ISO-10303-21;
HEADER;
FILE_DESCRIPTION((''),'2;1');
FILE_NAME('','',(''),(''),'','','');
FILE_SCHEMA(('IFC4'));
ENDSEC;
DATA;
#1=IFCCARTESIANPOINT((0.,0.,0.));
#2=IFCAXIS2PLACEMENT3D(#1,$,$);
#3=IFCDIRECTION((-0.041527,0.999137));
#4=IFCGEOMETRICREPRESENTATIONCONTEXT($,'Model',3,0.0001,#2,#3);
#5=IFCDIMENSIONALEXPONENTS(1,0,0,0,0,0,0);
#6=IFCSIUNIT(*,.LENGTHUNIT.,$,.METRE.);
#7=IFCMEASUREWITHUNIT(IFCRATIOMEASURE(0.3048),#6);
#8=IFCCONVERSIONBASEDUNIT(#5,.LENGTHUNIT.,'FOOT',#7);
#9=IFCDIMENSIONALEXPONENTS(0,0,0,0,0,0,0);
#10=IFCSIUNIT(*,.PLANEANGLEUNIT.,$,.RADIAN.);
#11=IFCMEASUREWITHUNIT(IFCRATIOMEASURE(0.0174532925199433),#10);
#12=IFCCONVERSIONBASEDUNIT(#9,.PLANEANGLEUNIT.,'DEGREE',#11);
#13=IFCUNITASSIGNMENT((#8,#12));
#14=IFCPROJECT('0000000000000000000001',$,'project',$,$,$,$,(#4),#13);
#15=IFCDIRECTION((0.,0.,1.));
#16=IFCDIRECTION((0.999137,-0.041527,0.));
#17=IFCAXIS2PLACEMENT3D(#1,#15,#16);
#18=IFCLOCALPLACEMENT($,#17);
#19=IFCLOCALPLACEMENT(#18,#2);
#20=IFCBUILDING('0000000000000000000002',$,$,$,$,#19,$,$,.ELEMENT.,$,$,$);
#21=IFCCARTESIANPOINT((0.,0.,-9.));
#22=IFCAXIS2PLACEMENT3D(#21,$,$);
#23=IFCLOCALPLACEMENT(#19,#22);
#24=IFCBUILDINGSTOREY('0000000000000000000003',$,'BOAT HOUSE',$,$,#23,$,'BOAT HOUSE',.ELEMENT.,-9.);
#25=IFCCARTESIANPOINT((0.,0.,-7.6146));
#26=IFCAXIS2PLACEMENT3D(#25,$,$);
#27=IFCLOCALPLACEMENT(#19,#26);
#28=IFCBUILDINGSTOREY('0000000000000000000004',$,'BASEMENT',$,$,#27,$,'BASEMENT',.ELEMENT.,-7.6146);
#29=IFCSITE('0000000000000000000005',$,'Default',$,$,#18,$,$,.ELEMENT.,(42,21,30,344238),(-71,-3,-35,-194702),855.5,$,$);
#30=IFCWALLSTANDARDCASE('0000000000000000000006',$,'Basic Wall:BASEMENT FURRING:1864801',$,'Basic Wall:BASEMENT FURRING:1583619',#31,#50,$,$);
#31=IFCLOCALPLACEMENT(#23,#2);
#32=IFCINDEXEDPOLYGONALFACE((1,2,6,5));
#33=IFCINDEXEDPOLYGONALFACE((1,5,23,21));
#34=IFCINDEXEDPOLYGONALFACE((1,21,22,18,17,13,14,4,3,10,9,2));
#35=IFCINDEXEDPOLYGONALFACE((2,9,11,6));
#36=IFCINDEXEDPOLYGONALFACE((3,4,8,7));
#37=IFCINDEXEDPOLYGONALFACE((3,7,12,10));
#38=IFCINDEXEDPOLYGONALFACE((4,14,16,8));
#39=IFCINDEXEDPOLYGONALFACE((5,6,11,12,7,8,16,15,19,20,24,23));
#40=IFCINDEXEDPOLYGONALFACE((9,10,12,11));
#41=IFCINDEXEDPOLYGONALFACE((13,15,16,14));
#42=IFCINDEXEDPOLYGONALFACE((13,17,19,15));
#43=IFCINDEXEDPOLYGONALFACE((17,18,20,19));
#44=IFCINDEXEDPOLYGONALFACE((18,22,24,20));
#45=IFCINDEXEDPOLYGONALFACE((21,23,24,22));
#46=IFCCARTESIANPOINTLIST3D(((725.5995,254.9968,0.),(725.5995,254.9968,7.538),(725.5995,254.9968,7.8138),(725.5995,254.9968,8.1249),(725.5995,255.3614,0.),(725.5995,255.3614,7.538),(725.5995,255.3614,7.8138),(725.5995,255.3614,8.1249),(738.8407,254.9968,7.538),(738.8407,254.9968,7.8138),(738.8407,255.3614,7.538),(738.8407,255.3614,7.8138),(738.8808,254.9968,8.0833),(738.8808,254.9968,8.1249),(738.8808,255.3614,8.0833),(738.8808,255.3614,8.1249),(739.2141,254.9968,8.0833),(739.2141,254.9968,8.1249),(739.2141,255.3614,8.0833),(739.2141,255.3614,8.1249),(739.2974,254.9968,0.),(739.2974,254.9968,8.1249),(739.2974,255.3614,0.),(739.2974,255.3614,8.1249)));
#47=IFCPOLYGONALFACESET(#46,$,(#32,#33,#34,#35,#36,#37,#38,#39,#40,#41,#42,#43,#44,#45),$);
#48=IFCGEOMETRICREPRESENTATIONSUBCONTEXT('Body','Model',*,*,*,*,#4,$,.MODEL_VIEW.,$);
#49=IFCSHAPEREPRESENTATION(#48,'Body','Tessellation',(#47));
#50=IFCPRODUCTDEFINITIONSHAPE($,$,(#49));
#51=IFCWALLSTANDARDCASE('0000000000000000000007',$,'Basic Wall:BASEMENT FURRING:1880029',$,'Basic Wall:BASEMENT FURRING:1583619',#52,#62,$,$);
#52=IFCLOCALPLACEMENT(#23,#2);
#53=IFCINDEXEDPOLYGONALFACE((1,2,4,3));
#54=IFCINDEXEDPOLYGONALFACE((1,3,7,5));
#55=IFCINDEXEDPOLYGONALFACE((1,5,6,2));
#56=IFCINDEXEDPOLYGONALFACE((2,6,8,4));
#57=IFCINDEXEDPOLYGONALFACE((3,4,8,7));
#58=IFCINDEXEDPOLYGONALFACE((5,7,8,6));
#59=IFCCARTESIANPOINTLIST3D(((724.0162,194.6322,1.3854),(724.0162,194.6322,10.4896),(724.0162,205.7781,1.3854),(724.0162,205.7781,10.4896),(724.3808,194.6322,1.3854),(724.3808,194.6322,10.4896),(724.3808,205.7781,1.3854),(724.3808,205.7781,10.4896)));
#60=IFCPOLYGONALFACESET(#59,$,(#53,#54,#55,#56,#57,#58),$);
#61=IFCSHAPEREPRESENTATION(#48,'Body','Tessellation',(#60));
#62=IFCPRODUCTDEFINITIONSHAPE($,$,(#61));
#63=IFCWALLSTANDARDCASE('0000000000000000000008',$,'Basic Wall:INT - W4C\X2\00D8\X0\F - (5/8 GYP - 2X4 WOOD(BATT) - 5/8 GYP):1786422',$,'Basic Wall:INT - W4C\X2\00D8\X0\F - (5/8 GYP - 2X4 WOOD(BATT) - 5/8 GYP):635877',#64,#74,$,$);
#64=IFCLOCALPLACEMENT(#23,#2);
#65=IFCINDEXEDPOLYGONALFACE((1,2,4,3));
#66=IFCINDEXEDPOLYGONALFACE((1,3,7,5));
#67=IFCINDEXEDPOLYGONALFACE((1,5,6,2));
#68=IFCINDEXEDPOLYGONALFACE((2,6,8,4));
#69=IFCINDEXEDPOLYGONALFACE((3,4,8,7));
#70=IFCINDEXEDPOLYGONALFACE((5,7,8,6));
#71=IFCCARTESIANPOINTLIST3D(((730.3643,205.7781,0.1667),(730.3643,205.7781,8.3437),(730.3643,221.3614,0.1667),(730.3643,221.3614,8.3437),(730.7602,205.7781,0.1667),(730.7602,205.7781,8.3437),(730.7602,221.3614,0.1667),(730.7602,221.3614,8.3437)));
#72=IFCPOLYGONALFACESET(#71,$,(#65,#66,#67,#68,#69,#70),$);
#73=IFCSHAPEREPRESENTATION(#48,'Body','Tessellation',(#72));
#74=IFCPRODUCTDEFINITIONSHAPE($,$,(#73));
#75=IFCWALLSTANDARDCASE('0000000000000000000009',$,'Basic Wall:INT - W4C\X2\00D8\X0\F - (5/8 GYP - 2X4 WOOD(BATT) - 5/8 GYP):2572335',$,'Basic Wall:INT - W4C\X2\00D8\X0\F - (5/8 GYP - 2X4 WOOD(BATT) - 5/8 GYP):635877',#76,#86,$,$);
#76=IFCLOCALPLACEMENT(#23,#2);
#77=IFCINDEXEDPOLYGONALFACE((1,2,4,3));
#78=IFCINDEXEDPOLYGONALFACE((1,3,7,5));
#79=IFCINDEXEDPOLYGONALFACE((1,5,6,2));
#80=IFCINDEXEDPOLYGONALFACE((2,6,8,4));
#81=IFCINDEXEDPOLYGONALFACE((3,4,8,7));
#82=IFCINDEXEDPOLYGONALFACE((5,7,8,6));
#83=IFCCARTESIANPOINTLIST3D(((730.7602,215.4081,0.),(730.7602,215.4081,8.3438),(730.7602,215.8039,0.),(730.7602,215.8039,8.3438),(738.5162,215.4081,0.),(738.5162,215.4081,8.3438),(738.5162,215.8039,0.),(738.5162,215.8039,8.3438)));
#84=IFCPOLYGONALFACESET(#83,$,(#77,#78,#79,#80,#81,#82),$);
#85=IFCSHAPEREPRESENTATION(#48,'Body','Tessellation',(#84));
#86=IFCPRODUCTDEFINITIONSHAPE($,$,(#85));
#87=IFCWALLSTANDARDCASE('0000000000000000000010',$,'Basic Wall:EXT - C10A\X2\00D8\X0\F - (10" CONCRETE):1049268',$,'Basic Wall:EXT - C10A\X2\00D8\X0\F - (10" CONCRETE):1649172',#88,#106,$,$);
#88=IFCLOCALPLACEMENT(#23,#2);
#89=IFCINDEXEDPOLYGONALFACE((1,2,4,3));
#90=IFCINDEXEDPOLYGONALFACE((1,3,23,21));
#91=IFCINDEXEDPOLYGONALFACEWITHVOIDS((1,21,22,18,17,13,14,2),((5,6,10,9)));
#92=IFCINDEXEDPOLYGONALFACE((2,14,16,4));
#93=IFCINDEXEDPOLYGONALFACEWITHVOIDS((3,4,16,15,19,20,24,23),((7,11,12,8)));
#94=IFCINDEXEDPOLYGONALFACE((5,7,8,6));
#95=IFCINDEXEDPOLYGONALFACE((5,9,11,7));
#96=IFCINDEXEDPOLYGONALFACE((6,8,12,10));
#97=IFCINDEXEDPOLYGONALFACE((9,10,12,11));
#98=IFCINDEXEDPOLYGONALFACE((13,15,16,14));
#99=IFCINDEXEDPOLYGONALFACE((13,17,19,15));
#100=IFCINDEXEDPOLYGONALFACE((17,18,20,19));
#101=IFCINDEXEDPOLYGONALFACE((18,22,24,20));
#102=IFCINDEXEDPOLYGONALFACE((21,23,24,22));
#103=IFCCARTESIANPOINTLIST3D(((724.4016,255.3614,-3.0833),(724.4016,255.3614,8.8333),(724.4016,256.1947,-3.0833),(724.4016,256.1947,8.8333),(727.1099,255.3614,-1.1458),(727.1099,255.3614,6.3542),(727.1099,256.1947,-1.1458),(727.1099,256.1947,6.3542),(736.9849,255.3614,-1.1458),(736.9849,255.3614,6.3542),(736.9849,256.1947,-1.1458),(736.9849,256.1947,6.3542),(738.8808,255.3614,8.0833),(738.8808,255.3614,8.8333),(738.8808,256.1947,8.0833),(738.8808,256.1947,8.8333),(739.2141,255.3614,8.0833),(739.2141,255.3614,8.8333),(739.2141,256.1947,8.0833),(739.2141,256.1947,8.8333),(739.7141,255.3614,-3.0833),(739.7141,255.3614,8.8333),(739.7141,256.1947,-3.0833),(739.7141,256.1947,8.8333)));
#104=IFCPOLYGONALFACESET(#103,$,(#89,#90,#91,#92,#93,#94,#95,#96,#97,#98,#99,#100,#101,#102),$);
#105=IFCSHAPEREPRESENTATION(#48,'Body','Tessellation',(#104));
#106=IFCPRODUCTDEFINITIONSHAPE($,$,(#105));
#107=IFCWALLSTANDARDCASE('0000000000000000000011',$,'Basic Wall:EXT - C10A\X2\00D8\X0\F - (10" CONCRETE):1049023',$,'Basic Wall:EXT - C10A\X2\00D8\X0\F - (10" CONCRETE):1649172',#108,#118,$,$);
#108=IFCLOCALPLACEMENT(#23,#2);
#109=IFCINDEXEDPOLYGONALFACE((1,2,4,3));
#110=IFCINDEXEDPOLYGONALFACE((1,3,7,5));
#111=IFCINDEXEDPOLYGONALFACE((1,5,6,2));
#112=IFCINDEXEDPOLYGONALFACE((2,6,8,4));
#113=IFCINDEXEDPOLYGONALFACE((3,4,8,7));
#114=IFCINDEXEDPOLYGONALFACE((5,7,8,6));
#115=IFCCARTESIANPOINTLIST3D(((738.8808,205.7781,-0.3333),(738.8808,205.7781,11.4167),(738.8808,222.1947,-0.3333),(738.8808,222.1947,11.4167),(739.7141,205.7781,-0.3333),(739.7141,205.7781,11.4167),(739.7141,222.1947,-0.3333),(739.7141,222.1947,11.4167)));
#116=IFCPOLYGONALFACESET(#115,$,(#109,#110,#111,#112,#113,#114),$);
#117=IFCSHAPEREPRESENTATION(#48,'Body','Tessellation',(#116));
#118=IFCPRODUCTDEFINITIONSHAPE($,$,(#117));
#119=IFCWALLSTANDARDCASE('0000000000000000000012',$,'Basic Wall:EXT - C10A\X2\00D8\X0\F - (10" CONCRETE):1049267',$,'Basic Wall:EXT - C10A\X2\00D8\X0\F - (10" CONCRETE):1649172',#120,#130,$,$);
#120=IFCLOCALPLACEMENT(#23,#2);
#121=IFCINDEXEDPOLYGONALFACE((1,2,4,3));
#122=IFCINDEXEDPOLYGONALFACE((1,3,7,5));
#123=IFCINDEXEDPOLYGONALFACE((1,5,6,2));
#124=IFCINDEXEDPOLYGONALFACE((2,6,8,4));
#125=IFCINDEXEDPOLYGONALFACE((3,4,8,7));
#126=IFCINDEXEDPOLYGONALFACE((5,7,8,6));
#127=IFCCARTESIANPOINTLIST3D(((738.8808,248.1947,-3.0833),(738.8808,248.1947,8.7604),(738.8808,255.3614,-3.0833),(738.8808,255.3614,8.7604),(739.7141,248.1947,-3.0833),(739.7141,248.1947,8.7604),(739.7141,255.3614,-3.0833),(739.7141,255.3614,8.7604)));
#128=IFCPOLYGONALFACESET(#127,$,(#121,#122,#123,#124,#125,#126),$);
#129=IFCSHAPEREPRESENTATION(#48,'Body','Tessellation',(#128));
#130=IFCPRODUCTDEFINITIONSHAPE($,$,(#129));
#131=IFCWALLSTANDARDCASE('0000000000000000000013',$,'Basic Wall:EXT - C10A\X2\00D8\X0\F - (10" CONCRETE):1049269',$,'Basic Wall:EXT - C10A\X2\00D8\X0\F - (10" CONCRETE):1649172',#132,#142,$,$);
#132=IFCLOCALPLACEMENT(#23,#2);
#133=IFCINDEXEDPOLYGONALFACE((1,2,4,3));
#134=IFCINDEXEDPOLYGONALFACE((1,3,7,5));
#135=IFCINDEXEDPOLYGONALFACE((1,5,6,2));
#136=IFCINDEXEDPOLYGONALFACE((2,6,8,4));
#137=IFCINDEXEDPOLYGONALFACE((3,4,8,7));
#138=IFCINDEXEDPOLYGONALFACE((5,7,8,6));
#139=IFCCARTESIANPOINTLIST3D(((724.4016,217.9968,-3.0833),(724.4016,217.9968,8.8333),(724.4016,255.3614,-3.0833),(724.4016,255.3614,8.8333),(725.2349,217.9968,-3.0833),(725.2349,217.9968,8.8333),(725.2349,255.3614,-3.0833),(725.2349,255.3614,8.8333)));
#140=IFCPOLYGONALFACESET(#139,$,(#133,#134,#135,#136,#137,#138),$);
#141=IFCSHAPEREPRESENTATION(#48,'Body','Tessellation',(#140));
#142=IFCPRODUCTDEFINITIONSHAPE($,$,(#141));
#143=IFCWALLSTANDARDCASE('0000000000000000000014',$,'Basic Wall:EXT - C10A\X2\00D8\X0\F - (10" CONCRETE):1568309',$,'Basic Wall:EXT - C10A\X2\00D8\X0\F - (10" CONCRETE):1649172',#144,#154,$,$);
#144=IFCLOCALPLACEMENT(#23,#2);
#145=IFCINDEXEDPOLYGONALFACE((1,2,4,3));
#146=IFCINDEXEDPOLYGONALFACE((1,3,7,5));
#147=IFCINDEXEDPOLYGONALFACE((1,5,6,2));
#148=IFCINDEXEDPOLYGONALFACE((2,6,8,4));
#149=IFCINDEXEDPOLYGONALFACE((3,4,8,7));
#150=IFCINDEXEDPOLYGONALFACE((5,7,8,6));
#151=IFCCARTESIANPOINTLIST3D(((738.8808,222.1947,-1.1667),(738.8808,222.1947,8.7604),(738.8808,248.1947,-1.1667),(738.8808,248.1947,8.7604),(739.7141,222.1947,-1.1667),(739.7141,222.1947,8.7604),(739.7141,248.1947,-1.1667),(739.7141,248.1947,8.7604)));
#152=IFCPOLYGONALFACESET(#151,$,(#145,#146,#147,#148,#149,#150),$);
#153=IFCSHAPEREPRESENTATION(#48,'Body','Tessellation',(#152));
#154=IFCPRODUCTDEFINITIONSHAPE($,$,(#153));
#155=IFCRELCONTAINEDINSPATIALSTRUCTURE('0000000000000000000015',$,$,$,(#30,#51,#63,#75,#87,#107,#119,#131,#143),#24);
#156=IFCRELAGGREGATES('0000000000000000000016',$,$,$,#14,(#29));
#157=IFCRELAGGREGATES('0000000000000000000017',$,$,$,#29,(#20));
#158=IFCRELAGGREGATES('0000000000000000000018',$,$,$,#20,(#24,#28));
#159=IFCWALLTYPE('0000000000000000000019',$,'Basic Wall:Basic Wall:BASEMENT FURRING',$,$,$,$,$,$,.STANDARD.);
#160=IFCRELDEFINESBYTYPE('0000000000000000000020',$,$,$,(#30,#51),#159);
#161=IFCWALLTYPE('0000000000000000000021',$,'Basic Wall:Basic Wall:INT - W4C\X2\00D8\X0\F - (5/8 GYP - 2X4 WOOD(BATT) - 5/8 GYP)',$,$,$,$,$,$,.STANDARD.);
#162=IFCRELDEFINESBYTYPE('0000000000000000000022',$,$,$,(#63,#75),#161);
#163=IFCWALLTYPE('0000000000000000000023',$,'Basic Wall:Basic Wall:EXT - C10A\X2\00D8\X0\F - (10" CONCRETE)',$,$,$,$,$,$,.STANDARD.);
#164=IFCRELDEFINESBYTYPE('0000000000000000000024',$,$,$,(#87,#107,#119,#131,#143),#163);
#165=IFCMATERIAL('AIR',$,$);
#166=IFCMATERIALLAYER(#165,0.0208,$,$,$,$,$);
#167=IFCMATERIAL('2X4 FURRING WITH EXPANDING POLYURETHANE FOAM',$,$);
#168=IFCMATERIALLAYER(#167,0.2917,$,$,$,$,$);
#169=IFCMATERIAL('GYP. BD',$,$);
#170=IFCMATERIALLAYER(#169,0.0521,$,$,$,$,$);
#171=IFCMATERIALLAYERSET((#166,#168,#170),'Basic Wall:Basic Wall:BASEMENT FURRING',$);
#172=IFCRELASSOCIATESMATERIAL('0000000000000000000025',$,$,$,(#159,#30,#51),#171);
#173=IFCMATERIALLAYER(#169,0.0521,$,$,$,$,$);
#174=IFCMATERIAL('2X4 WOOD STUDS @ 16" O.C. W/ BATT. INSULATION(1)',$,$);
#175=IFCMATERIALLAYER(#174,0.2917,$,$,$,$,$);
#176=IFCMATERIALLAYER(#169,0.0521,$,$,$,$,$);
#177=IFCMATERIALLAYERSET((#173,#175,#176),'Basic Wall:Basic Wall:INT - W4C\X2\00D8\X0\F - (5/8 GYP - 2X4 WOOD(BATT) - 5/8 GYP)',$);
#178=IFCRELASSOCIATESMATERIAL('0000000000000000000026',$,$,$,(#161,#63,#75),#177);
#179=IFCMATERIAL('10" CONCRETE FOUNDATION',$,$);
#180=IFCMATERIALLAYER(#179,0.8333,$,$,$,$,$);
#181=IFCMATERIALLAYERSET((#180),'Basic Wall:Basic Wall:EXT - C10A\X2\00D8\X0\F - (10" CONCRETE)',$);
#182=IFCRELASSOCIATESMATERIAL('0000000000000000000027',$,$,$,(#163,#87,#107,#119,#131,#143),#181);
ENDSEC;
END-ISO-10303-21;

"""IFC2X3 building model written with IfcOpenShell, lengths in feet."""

from ifc_helpers import new_model, entity, si_unit, converted_unit, direction, frame, frame_2d, origin, origin_2d_with_axis, place, context, subcontext, project, spatial, rectangle, extrude, material, layer, layer_set, layer_usage, type_object, element, save


model = new_model("IFC2X3")

# Units and contexts
model_context = context("Model", 3, precision=0.0001, world=origin(), true_north=direction((-0.041527, 0.999137)))
body_context = subcontext(model_context, "Body", "Model", "MODEL_VIEW")
ifc_project = project(units=[converted_unit("LENGTHUNIT", "FOOT", entity("IfcRatioMeasure", 0.3048), si_unit("LENGTHUNIT", "METRE"), dimensions=[1, 0, 0, 0, 0, 0, 0]), converted_unit("PLANEANGLEUNIT", "DEGREE", entity("IfcRatioMeasure", 0.0174532925199433), si_unit("PLANEANGLEUNIT", "RADIAN"), dimensions=[0, 0, 0, 0, 0, 0, 0])], contexts=[model_context])

# Site, building, storey
site_placement = place(None, frame((0.0, 0.0, 0.0), z_axis=(0.0, 0.0, 1.0), x_axis=(0.999137, -0.041527, 0.0)))
site = spatial("IfcSite", under=ifc_project, at=site_placement, Name="Default", CompositionType="ELEMENT", RefLatitude=(42, 21, 30, 344238), RefLongitude=(-71, -3, -35, -194702), RefElevation=855.5)
building_placement = place(site_placement, origin())
building = spatial("IfcBuilding", under=site, at=building_placement, CompositionType="ELEMENT")
storey_1_placement = place(building_placement, frame((0.0, 0.0, -9.0)))
storey_1 = spatial("IfcBuildingStorey", under=building, at=storey_1_placement, Name="BOAT HOUSE", LongName="BOAT HOUSE", CompositionType="ELEMENT", Elevation=-9.0)

# Wall, openings
ifc_material_1 = material(Name="AIR")
ifc_layer_1 = layer(ifc_material_1, 0.0208)
ifc_material_2 = material(Name="2X4 FURRING WITH EXPANDING POLYURETHANE FOAM")
ifc_layer_2 = layer(ifc_material_2, 0.2917)
ifc_material_3 = material(Name="GYP. BD")
ifc_layer_3 = layer(ifc_material_3, 0.0521)
ifc_layer_set_1 = layer_set([ifc_layer_1, ifc_layer_2, ifc_layer_3], Name="Basic Wall:Basic Wall:BASEMENT FURRING")
ifc_layer_usage_1 = layer_usage(ifc_layer_set_1, "AXIS2", "NEGATIVE", 0.1823)
wall_type_1 = type_object("IfcWallType", Name="Basic Wall:Basic Wall:BASEMENT FURRING", PredefinedType="STANDARD", material=ifc_layer_set_1)
wall_1_placement = place(storey_1_placement, frame((725.5995, 255.1791, 0.0)))
wall_1 = element("IfcWallStandardCase", 1, at=wall_1_placement, inside=storey_1, type_object=wall_type_1, material=ifc_layer_usage_1, Name="Basic Wall:BASEMENT FURRING:1864801", ObjectType="Basic Wall:BASEMENT FURRING:1583619", context=body_context, shape_type="SweptSolid", body=[
    extrude(rectangle(XDim=13.6979, YDim=0.3646, at=frame_2d((6.849, 0.0), x_axis=(-1.0, 0.0))), origin(), (0.0, 0.0, 1.0), 8.1249),
])
opening_1_placement = place(wall_1_placement, origin())
element("IfcOpeningElement", 2, at=opening_1_placement, cuts=wall_1, ObjectType="Opening", context=body_context, shape_type="SweptSolid", body=[
    extrude(rectangle(XDim=0.2759, YDim=13.2412, at=origin_2d_with_axis()), frame((6.6206, -0.1823, 7.6759), z_axis=(0.0, 1.0, 0.0), x_axis=(0.0, 0.0, -1.0)), (0.0, 0.0, 1.0), 0.3646),
])
opening_2_placement = place(wall_1_placement, origin())
element("IfcOpeningElement", 3, at=opening_2_placement, cuts=wall_1, ObjectType="Opening", context=body_context, shape_type="SweptSolid", body=[
    extrude(rectangle(XDim=1.1042, YDim=0.3333, at=frame_2d((0.0, 0.0), x_axis=(1.0, 0.0))), frame((13.4479, -0.1823, 8.6354), z_axis=(0.0, 1.0, 0.0), x_axis=(0.0, 0.0, -1.0)), (0.0, 0.0, 1.0), 0.3646),
])

# Wall
ifc_layer_usage_2 = layer_usage(ifc_layer_set_1, "AXIS2", "NEGATIVE", 0.1823)
wall_2_placement = place(storey_1_placement, frame((724.1985, 205.7781, 1.3854), z_axis=(0.0, 0.0, 1.0), x_axis=(0.0, -1.0, 0.0)))
element("IfcWallStandardCase", 4, at=wall_2_placement, inside=storey_1, type_object=wall_type_1, material=ifc_layer_usage_2, Name="Basic Wall:BASEMENT FURRING:1880029", ObjectType="Basic Wall:BASEMENT FURRING:1583619", context=body_context, shape_type="SweptSolid", body=[
    extrude(rectangle(XDim=11.1458, YDim=0.3646, at=frame_2d((5.5729, 0.0), x_axis=(-1.0, 0.0))), origin(), (0.0, 0.0, 1.0), 9.1042),
])

# Shared definitions
ifc_layer_4 = layer(ifc_material_3, 0.0521)
ifc_material_4 = material(Name="2X4 WOOD STUDS @ 16\" O.C. W/ BATT. INSULATION(1)")
ifc_layer_5 = layer(ifc_material_4, 0.2917)
ifc_layer_6 = layer(ifc_material_3, 0.0521)
ifc_layer_set_2 = layer_set([ifc_layer_4, ifc_layer_5, ifc_layer_6], Name="Basic Wall:Basic Wall:INT - W4CØF - (5/8 GYP - 2X4 WOOD(BATT) - 5/8 GYP)")
wall_type_2 = type_object("IfcWallType", Name="Basic Wall:Basic Wall:INT - W4CØF - (5/8 GYP - 2X4 WOOD(BATT) - 5/8 GYP)", PredefinedType="STANDARD", material=ifc_layer_set_2)

# Shared definitions
storey_2_placement = place(building_placement, frame((0.0, 0.0, -7.6146)))
storey_2 = spatial("IfcBuildingStorey", under=building, at=storey_2_placement, Name="BASEMENT", LongName="BASEMENT", CompositionType="ELEMENT", Elevation=-7.6146)

# Walls
ifc_layer_usage_3 = layer_usage(ifc_layer_set_2, "AXIS2", "NEGATIVE", 0.1979)
wall_3_placement = place(storey_1_placement, frame((730.5622, 205.7781, 0.1667), z_axis=(0.0, 0.0, 1.0), x_axis=(0.0, 1.0, 0.0)))
element("IfcWallStandardCase", 5, at=wall_3_placement, inside=storey_1, type_object=wall_type_2, material=ifc_layer_usage_3, Name="Basic Wall:INT - W4CØF - (5/8 GYP - 2X4 WOOD(BATT) - 5/8 GYP):1786422", ObjectType="Basic Wall:INT - W4CØF - (5/8 GYP - 2X4 WOOD(BATT) - 5/8 GYP):635877", context=body_context, shape_type="SweptSolid", body=[
    extrude(rectangle(XDim=15.5833, YDim=0.3958, at=frame_2d((7.7917, 0.0), x_axis=(-1.0, 0.0))), origin(), (0.0, 0.0, 1.0), 8.1771),
])
ifc_layer_usage_4 = layer_usage(ifc_layer_set_2, "AXIS2", "NEGATIVE", 0.1979)
wall_4_placement = place(storey_1_placement, frame((738.5162, 215.606, 0.0), z_axis=(0.0, 0.0, 1.0), x_axis=(-1.0, 0.0, 0.0)))
element("IfcWallStandardCase", 6, at=wall_4_placement, inside=storey_1, type_object=wall_type_2, material=ifc_layer_usage_4, Name="Basic Wall:INT - W4CØF - (5/8 GYP - 2X4 WOOD(BATT) - 5/8 GYP):2572335", ObjectType="Basic Wall:INT - W4CØF - (5/8 GYP - 2X4 WOOD(BATT) - 5/8 GYP):635877", context=body_context, shape_type="SweptSolid", body=[
    extrude(rectangle(XDim=7.756, YDim=0.3958, at=frame_2d((3.878, 0.0), x_axis=(-1.0, 0.0))), origin(), (0.0, 0.0, 1.0), 8.3438),
])

# Wall, openings
ifc_material_5 = material(Name="10\" CONCRETE FOUNDATION")
ifc_layer_7 = layer(ifc_material_5, 0.8333)
ifc_layer_set_3 = layer_set([ifc_layer_7], Name="Basic Wall:Basic Wall:EXT - C10AØF - (10\" CONCRETE)")
ifc_layer_usage_5 = layer_usage(ifc_layer_set_3, "AXIS2", "NEGATIVE", 0.4167)
wall_type_3 = type_object("IfcWallType", Name="Basic Wall:Basic Wall:EXT - C10AØF - (10\" CONCRETE)", PredefinedType="STANDARD", material=ifc_layer_set_3)
wall_5_placement = place(storey_1_placement, frame((724.4016, 255.7781, -3.0833)))
wall_5 = element("IfcWallStandardCase", 7, at=wall_5_placement, inside=storey_1, type_object=wall_type_3, material=ifc_layer_usage_5, Name="Basic Wall:EXT - C10AØF - (10\" CONCRETE):1049268", ObjectType="Basic Wall:EXT - C10AØF - (10\" CONCRETE):1649172", context=body_context, shape_type="SweptSolid", body=[
    extrude(rectangle(XDim=15.3125, YDim=0.8333, at=frame_2d((7.6563, 0.0), x_axis=(-1.0, 0.0))), origin(), (0.0, 0.0, 1.0), 11.9167),
])
opening_3_placement = place(wall_5_placement, origin())
element("IfcOpeningElement", 8, at=opening_3_placement, cuts=wall_5, ObjectType="Opening", context=body_context, shape_type="SweptSolid", body=[
    extrude(rectangle(XDim=1.1042, YDim=0.3333, at=frame_2d((0.0, 0.0), x_axis=(1.0, 0.0))), frame((14.6458, -0.4167, 11.7188), z_axis=(0.0, 1.0, 0.0), x_axis=(0.0, 0.0, -1.0)), (0.0, 0.0, 1.0), 0.8333),
])
opening_4_placement = place(wall_5_placement, origin())
element("IfcOpeningElement", 9, at=opening_4_placement, cuts=wall_5, ObjectType="Opening", context=body_context, shape_type="SweptSolid", body=[
    extrude(rectangle(XDim=7.5, YDim=9.875, at=origin_2d_with_axis()), frame((7.6458, -0.4167, 5.6875), z_axis=(0.0, 1.0, 0.0), x_axis=(0.0, 0.0, -1.0)), (0.0, 0.0, 1.0), 0.8333),
])

# Walls
ifc_layer_usage_6 = layer_usage(ifc_layer_set_3, "AXIS2", "NEGATIVE", 0.4167)
wall_6_placement = place(storey_1_placement, frame((739.2974, 222.1947, -0.3333), z_axis=(0.0, 0.0, 1.0), x_axis=(0.0, -1.0, 0.0)))
element("IfcWallStandardCase", 10, at=wall_6_placement, inside=storey_1, type_object=wall_type_3, material=ifc_layer_usage_6, Name="Basic Wall:EXT - C10AØF - (10\" CONCRETE):1049023", ObjectType="Basic Wall:EXT - C10AØF - (10\" CONCRETE):1649172", context=body_context, shape_type="SweptSolid", body=[
    extrude(rectangle(XDim=16.4167, YDim=0.8333, at=frame_2d((8.2083, 0.0), x_axis=(-1.0, 0.0))), origin(), (0.0, 0.0, 1.0), 11.75),
])
ifc_layer_usage_7 = layer_usage(ifc_layer_set_3, "AXIS2", "NEGATIVE", 0.4167)
wall_7_placement = place(storey_1_placement, frame((739.2974, 255.3614, -3.0833), z_axis=(0.0, 0.0, 1.0), x_axis=(0.0, -1.0, 0.0)))
element("IfcWallStandardCase", 11, at=wall_7_placement, inside=storey_1, type_object=wall_type_3, material=ifc_layer_usage_7, Name="Basic Wall:EXT - C10AØF - (10\" CONCRETE):1049267", ObjectType="Basic Wall:EXT - C10AØF - (10\" CONCRETE):1649172", context=body_context, shape_type="SweptSolid", body=[
    extrude(rectangle(XDim=7.1667, YDim=0.8333, at=frame_2d((3.5833, 0.0), x_axis=(-1.0, 0.0))), origin(), (0.0, 0.0, 1.0), 11.8438),
])
ifc_layer_usage_8 = layer_usage(ifc_layer_set_3, "AXIS2", "NEGATIVE", 0.4167)
wall_8_placement = place(storey_1_placement, frame((724.8183, 217.9968, -3.0833), z_axis=(0.0, 0.0, 1.0), x_axis=(0.0, 1.0, 0.0)))
element("IfcWallStandardCase", 12, at=wall_8_placement, inside=storey_1, type_object=wall_type_3, material=ifc_layer_usage_8, Name="Basic Wall:EXT - C10AØF - (10\" CONCRETE):1049269", ObjectType="Basic Wall:EXT - C10AØF - (10\" CONCRETE):1649172", context=body_context, shape_type="SweptSolid", body=[
    extrude(rectangle(XDim=37.3646, YDim=0.8333, at=frame_2d((18.6823, 0.0), x_axis=(-1.0, 0.0))), origin(), (0.0, 0.0, 1.0), 11.9167),
])
ifc_layer_usage_9 = layer_usage(ifc_layer_set_3, "AXIS2", "NEGATIVE", 0.4167)
wall_9_placement = place(storey_1_placement, frame((739.2974, 248.1947, -1.1667), z_axis=(0.0, 0.0, 1.0), x_axis=(0.0, -1.0, 0.0)))
element("IfcWallStandardCase", 13, at=wall_9_placement, inside=storey_1, type_object=wall_type_3, material=ifc_layer_usage_9, Name="Basic Wall:EXT - C10AØF - (10\" CONCRETE):1568309", ObjectType="Basic Wall:EXT - C10AØF - (10\" CONCRETE):1649172", context=body_context, shape_type="SweptSolid", body=[
    extrude(rectangle(XDim=26.0, YDim=0.8333, at=frame_2d((13.0, 0.0), x_axis=(-1.0, 0.0))), origin(), (0.0, 0.0, 1.0), 9.9271),
])

save(model, "model.ifc")
